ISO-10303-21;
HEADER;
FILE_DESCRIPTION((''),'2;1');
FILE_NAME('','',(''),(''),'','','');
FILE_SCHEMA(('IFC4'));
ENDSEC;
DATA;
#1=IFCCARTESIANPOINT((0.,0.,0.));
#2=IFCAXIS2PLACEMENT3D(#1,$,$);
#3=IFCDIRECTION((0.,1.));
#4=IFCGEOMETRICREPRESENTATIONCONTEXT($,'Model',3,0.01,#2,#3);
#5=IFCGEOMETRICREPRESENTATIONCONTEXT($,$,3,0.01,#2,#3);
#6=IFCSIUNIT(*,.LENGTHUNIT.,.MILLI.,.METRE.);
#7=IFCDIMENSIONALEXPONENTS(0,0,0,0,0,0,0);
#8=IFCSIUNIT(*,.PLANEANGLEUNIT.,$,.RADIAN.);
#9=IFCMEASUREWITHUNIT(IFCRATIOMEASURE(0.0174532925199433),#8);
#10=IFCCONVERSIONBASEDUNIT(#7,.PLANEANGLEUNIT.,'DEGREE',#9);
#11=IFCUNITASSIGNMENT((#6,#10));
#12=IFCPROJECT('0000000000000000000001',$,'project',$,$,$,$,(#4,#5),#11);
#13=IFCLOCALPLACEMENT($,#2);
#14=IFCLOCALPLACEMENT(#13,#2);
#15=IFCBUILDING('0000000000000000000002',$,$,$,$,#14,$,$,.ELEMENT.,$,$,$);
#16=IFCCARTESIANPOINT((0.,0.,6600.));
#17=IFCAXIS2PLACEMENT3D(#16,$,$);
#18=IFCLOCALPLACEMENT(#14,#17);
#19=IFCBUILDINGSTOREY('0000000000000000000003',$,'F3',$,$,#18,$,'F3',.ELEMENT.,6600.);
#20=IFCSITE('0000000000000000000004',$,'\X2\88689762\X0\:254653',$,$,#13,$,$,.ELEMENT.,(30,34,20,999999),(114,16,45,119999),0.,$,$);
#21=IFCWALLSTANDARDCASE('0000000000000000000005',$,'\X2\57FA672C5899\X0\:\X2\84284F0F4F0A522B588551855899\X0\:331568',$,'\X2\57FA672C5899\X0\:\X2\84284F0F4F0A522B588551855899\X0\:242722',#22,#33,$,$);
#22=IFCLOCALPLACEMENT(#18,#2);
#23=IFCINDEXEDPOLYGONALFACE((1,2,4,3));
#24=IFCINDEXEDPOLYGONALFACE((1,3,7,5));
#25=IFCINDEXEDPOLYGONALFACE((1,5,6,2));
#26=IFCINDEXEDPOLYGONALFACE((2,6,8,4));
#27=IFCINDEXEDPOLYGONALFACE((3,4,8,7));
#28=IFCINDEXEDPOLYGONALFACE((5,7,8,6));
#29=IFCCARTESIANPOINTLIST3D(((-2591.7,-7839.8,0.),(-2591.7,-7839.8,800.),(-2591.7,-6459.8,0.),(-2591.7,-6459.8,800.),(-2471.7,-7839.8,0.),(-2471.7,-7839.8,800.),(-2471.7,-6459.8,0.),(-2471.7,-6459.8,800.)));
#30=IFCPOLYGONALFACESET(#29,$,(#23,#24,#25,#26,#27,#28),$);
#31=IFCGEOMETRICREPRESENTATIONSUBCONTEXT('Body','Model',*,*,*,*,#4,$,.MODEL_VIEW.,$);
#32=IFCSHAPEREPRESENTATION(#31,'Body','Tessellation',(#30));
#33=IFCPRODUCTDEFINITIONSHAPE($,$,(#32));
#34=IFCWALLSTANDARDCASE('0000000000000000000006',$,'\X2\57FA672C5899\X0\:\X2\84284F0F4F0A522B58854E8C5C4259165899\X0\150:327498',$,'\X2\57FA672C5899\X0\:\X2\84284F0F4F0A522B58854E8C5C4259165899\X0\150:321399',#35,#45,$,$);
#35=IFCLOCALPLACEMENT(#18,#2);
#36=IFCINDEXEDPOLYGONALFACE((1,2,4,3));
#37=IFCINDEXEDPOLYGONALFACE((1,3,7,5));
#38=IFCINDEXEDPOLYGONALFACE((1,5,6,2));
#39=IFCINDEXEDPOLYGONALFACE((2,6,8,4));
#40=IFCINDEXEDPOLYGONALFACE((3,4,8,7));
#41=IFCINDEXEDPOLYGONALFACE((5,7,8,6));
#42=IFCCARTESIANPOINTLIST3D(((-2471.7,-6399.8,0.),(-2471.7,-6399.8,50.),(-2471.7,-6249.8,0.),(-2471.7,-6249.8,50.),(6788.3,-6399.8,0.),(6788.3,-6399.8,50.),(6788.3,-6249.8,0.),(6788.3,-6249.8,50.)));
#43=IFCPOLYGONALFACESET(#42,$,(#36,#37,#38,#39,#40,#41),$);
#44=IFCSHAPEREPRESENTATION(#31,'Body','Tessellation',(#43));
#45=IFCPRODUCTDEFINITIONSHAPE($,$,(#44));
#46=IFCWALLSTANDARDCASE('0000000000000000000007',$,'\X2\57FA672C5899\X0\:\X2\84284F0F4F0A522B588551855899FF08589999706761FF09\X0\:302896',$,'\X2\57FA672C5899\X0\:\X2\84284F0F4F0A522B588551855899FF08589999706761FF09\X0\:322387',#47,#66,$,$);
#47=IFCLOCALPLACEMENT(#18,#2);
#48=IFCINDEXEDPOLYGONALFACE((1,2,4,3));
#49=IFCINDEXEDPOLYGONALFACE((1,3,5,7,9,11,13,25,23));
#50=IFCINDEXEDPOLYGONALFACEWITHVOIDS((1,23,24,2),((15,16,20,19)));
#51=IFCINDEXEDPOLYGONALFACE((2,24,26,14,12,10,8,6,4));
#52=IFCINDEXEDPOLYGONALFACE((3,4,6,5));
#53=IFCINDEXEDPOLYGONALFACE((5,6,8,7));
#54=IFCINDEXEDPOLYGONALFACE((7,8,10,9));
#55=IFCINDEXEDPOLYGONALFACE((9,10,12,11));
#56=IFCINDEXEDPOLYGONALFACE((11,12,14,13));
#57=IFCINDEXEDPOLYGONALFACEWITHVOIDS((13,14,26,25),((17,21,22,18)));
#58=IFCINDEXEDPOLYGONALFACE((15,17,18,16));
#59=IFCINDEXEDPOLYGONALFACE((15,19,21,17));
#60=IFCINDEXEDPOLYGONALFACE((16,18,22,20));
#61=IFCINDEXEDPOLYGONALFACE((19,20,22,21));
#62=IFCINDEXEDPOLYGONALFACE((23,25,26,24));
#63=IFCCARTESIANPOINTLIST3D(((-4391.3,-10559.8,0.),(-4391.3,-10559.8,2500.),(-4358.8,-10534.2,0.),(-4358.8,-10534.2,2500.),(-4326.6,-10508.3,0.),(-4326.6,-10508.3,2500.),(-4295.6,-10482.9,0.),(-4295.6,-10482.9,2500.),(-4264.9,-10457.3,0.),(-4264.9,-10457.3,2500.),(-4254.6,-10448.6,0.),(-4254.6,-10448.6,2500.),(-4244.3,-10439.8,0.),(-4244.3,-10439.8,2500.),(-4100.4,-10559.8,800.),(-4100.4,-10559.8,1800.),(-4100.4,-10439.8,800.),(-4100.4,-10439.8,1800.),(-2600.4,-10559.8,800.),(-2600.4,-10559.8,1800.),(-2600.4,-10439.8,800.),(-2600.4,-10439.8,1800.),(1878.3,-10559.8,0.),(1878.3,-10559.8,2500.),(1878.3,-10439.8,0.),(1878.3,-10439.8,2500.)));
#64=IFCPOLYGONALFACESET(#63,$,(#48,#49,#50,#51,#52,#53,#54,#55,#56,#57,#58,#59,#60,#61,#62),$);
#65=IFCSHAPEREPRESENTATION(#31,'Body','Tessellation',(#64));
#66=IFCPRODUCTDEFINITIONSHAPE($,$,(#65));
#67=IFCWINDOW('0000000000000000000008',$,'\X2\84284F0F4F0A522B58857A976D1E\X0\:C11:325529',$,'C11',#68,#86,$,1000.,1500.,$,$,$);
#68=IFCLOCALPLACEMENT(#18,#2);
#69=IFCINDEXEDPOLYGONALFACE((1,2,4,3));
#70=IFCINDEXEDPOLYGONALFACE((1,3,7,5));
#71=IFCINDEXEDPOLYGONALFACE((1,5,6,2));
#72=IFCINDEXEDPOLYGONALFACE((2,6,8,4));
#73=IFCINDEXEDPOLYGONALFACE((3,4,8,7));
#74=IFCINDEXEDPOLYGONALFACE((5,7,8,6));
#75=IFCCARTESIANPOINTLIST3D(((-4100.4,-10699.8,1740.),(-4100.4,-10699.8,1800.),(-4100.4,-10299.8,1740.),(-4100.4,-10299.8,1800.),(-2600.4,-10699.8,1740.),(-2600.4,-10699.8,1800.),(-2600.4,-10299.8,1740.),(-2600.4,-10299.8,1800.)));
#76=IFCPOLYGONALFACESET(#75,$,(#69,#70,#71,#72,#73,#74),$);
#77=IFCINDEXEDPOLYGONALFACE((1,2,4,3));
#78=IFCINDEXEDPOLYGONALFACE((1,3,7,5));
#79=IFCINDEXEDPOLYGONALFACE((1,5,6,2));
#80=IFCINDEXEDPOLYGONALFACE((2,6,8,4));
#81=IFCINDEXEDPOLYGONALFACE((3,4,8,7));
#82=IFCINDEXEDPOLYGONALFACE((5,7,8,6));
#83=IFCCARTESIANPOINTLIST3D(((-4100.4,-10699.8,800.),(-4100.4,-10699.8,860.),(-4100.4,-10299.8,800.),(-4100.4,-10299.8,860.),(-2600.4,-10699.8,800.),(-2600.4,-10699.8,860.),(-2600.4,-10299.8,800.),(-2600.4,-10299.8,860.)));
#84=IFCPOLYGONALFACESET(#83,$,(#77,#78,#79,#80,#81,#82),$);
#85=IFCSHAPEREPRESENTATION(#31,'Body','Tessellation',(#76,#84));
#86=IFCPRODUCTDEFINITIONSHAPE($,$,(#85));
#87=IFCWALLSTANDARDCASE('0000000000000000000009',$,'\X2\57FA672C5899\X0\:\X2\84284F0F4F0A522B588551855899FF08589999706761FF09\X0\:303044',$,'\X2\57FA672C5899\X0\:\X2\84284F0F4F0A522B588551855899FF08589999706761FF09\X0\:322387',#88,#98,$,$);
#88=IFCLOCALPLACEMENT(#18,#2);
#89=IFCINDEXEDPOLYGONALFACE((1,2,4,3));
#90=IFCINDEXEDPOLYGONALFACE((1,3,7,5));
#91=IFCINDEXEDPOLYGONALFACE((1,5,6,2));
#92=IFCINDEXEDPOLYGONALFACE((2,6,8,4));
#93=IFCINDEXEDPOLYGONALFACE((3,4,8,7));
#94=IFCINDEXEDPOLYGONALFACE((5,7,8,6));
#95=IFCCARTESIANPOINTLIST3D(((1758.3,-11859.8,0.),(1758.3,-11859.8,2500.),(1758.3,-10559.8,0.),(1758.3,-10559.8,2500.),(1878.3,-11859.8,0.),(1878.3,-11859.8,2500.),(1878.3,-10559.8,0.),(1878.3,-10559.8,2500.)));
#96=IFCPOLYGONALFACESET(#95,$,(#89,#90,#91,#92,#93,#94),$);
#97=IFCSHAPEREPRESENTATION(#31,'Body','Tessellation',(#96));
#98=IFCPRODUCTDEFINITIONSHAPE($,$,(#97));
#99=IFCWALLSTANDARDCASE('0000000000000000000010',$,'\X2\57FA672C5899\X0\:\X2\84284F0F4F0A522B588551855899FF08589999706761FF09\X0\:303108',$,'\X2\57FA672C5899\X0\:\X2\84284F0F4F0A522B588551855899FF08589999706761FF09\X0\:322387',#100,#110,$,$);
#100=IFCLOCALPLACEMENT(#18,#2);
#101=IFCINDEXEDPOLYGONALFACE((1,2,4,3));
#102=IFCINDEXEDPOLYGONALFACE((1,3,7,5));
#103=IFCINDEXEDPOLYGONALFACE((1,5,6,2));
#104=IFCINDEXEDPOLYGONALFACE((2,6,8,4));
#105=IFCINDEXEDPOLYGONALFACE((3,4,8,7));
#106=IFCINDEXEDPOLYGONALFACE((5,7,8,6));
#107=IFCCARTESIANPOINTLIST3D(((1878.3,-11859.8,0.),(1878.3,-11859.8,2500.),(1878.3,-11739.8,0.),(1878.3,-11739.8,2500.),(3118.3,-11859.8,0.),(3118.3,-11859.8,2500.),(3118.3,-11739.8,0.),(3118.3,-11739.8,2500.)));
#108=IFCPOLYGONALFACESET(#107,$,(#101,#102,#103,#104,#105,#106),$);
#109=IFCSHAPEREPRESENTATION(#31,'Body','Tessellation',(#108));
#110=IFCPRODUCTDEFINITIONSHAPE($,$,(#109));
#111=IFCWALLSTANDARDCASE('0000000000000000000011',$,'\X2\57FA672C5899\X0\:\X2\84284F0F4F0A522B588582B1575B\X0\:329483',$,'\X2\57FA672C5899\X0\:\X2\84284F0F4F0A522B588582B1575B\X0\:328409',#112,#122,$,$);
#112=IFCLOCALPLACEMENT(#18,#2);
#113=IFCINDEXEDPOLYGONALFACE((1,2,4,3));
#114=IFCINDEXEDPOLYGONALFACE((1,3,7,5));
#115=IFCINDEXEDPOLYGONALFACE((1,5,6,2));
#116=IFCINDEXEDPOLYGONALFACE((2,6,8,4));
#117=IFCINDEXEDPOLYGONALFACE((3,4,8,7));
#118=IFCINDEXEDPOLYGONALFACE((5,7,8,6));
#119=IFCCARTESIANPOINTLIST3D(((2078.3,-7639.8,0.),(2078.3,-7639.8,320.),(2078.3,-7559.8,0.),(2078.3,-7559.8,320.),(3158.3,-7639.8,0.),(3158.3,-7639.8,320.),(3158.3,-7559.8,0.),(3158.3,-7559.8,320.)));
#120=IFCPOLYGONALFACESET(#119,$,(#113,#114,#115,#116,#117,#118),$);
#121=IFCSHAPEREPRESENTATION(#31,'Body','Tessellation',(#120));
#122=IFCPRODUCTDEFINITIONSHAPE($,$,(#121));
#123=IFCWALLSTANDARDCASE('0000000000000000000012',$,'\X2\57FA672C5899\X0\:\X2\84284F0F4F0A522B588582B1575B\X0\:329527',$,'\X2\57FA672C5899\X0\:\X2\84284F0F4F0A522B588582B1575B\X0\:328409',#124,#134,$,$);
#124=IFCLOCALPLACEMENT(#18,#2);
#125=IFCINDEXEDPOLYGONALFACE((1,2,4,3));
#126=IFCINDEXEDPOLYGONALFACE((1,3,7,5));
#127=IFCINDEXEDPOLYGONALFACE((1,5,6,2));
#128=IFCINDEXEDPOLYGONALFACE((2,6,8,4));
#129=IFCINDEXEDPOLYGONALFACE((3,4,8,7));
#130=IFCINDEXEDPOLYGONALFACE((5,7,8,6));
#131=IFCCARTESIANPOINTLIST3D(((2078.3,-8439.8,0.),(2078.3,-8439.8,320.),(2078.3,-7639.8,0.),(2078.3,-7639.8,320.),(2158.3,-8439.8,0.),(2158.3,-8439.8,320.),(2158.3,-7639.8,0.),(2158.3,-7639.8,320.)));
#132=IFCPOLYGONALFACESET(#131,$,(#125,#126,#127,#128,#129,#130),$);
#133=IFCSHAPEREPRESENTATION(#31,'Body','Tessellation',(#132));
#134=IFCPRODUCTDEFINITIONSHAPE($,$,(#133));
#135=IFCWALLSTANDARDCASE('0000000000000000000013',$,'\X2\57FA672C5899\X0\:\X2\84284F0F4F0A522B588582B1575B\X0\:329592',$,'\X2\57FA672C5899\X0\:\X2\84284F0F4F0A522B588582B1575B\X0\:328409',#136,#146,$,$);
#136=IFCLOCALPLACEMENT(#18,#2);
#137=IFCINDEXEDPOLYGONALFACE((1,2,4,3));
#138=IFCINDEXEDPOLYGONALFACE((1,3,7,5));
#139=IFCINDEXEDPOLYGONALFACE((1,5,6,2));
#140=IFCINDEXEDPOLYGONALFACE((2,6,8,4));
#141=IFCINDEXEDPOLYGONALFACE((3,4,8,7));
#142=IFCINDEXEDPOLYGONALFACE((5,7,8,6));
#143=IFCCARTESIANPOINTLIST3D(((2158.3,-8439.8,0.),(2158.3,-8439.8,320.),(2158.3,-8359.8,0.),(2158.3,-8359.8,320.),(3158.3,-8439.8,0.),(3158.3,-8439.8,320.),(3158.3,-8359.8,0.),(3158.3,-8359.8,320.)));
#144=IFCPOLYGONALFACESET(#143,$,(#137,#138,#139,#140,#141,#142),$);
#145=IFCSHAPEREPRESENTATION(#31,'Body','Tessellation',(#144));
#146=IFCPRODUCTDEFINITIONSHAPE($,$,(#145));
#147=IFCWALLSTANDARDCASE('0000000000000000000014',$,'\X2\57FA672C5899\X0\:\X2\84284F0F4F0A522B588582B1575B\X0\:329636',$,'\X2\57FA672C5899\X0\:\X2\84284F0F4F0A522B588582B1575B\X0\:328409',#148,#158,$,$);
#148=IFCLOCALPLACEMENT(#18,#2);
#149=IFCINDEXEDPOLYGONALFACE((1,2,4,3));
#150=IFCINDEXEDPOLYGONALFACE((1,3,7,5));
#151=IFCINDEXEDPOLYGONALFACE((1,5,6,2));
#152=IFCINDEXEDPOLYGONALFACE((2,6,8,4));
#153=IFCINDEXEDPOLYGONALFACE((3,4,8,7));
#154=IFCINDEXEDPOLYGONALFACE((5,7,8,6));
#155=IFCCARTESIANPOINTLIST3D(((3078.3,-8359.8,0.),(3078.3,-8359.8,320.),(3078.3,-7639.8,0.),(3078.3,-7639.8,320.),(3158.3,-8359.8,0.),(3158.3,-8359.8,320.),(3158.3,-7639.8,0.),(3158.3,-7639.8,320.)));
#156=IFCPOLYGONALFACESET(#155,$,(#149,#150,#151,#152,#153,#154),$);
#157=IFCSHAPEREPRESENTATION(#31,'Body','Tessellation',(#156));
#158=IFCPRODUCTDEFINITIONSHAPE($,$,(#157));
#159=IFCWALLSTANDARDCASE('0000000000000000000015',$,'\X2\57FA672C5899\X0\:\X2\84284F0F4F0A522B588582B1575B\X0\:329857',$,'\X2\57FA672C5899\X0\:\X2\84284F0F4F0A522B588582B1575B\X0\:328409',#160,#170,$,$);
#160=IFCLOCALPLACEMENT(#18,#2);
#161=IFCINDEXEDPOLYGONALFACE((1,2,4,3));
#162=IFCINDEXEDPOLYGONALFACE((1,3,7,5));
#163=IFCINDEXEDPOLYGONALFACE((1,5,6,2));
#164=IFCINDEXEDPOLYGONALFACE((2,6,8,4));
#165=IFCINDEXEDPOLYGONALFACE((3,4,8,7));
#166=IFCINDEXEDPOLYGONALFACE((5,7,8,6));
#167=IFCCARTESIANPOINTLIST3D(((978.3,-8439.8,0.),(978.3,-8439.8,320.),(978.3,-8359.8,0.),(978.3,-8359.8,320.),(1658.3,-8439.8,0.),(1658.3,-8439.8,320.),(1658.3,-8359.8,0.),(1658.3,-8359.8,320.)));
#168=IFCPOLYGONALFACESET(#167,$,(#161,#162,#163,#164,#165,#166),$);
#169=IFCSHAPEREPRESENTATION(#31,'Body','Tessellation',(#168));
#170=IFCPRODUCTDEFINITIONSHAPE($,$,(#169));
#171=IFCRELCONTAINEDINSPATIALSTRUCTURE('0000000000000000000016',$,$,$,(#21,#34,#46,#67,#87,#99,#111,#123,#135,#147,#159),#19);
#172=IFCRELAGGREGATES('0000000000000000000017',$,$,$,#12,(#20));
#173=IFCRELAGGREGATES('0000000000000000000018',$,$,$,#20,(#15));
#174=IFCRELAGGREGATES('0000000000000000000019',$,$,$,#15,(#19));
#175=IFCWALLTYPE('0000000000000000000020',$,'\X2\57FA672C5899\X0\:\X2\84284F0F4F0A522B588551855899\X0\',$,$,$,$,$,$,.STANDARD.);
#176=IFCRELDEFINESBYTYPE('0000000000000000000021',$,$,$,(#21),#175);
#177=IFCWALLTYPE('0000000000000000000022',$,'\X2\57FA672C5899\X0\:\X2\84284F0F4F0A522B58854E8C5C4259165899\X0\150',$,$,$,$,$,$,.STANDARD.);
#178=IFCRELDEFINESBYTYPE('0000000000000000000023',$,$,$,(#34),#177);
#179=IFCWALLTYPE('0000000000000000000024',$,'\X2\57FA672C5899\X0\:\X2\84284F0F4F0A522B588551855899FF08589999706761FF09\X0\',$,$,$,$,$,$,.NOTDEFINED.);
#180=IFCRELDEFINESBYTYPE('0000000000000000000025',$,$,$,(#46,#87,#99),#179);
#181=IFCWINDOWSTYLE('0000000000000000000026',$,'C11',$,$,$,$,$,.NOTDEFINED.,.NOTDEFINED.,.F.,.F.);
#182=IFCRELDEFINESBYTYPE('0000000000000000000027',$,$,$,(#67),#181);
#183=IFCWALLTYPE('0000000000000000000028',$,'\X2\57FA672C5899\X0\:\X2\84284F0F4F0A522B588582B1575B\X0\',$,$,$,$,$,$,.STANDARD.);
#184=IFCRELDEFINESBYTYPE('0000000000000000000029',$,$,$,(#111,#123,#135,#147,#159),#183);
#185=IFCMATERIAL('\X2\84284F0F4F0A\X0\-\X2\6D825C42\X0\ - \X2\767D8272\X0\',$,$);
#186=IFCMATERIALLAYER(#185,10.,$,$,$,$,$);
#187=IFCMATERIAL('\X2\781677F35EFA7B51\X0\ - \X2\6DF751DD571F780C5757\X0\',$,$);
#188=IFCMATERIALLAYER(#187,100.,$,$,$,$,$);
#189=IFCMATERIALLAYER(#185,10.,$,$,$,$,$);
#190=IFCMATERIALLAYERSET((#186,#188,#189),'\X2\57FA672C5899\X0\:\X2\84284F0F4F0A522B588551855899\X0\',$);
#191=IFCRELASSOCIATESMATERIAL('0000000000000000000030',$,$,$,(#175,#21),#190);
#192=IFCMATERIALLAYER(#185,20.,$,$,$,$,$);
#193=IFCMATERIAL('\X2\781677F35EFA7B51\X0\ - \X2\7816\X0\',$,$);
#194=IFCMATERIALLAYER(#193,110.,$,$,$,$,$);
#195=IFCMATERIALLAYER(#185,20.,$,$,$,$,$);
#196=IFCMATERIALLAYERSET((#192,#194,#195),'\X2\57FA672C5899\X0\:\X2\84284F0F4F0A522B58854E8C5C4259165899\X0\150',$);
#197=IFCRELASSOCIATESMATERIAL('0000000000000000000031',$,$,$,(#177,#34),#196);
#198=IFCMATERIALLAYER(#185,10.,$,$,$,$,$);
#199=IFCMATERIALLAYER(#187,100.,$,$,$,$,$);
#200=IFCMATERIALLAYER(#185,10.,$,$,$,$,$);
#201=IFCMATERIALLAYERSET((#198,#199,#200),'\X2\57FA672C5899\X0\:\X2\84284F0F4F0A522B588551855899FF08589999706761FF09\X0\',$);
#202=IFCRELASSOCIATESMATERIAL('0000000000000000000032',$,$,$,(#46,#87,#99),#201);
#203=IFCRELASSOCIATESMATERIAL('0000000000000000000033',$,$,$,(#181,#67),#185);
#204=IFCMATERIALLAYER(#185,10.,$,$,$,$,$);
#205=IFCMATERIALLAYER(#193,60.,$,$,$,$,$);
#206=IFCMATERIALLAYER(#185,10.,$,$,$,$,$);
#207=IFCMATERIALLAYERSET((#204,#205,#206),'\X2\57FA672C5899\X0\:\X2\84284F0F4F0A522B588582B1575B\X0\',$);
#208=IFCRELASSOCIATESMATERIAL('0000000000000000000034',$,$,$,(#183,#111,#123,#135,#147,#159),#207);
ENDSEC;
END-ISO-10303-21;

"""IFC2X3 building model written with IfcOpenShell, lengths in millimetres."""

from ifc_helpers import new_model, entity, si_unit, converted_unit, direction, frame, frame_2d, origin, origin_2d_with_axis, place, context, subcontext, project, spatial, polyline, rectangle, outline, extrude, source, transform, mapped, material, layer, layer_set, layer_usage, type_object, type_shapes, element, fill, save


model = new_model("IFC2X3")

# Units and contexts
model_context = context("Model", 3, precision=0.01, world=origin(), true_north=direction((0.0, 1.0)))
context_of_model = context(None, 3, precision=0.01, world=origin(), true_north=direction((0.0, 1.0)))
body_context = subcontext(model_context, "Body", "Model", "MODEL_VIEW")
ifc_project = project(units=[si_unit("LENGTHUNIT", "METRE", prefix="MILLI"), converted_unit("PLANEANGLEUNIT", "DEGREE", entity("IfcRatioMeasure", 0.0174532925199433), si_unit("PLANEANGLEUNIT", "RADIAN"), dimensions=[0, 0, 0, 0, 0, 0, 0])], contexts=[model_context, context_of_model])

# Site, building, storey
site_placement = place(None, origin())
site = spatial("IfcSite", under=ifc_project, at=site_placement, Name="表面:254653", CompositionType="ELEMENT", RefLatitude=(30, 34, 20, 999999), RefLongitude=(114, 16, 45, 119999), RefElevation=0.0)
building_placement = place(site_placement, origin())
building = spatial("IfcBuilding", under=site, at=building_placement, CompositionType="ELEMENT")
storey_placement = place(building_placement, frame((0.0, 0.0, 6600.0)))
storey = spatial("IfcBuildingStorey", under=building, at=storey_placement, Name="F3", LongName="F3", CompositionType="ELEMENT", Elevation=6600.0)

# Shared definitions
ifc_material_1 = material(Name="萨伏伊-涂层 - 白色")

# Walls
ifc_layer_1 = layer(ifc_material_1, 10.0)
ifc_material_2 = material(Name="砖石建筑 - 混凝土砌块")
ifc_layer_2 = layer(ifc_material_2, 100.0)
ifc_layer_3 = layer(ifc_material_1, 10.0)
ifc_layer_set_1 = layer_set([ifc_layer_1, ifc_layer_2, ifc_layer_3], Name="基本墙:萨伏伊别墅内墙")
ifc_layer_usage_1 = layer_usage(ifc_layer_set_1, "AXIS2", "NEGATIVE", 60.0)
wall_type_1 = type_object("IfcWallType", Name="基本墙:萨伏伊别墅内墙", PredefinedType="STANDARD", material=ifc_layer_set_1)
wall_1_placement = place(storey_placement, frame((-2531.7, -6459.8, 0.0), z_axis=(0.0, 0.0, 1.0), x_axis=(0.0, -1.0, 0.0)))
element("IfcWallStandardCase", 1, at=wall_1_placement, inside=storey, type_object=wall_type_1, material=ifc_layer_usage_1, Name="基本墙:萨伏伊别墅内墙:331568", ObjectType="基本墙:萨伏伊别墅内墙:242722", context=body_context, shape_type="SweptSolid", body=[
    extrude(rectangle(XDim=1380.0, YDim=120.0, at=frame_2d((690.0, 0.0), x_axis=(-1.0, 0.0))), origin(), (0.0, 0.0, 1.0), 800.0),
])
ifc_layer_4 = layer(ifc_material_1, 20.0)
ifc_material_3 = material(Name="砖石建筑 - 砖")
ifc_layer_5 = layer(ifc_material_3, 110.0)
ifc_layer_6 = layer(ifc_material_1, 20.0)
ifc_layer_set_2 = layer_set([ifc_layer_4, ifc_layer_5, ifc_layer_6], Name="基本墙:萨伏伊别墅二层外墙150")
ifc_layer_usage_2 = layer_usage(ifc_layer_set_2, "AXIS2", "NEGATIVE", 75.0)
wall_type_2 = type_object("IfcWallType", Name="基本墙:萨伏伊别墅二层外墙150", PredefinedType="STANDARD", material=ifc_layer_set_2)
wall_2_placement = place(storey_placement, frame((6788.3, -6324.8, 0.0), z_axis=(0.0, 0.0, 1.0), x_axis=(-1.0, 0.0, 0.0)))
element("IfcWallStandardCase", 2, at=wall_2_placement, inside=storey, type_object=wall_type_2, material=ifc_layer_usage_2, Name="基本墙:萨伏伊别墅二层外墙150:327498", ObjectType="基本墙:萨伏伊别墅二层外墙150:321399", context=body_context, shape_type="SweptSolid", body=[
    extrude(rectangle(XDim=9260.0, YDim=150.0, at=frame_2d((4630.0, 0.0), x_axis=(-1.0, 0.0))), origin(), (0.0, 0.0, 1.0), 50.0),
])

# Wall, opening, window
ifc_layer_7 = layer(ifc_material_1, 10.0)
ifc_layer_8 = layer(ifc_material_2, 100.0)
ifc_layer_9 = layer(ifc_material_1, 10.0)
ifc_layer_set_3 = layer_set([ifc_layer_7, ifc_layer_8, ifc_layer_9], Name="基本墙:萨伏伊别墅内墙（墙饰条）")
ifc_layer_usage_3 = layer_usage(ifc_layer_set_3, "AXIS2", "NEGATIVE", 60.0)
wall_type_3 = type_object("IfcWallType", Name="基本墙:萨伏伊别墅内墙（墙饰条）", PredefinedType="NOTDEFINED")
wall_3_placement = place(storey_placement, frame((-4391.3, -10499.8, 0.0)))
wall_3 = element("IfcWallStandardCase", 3, at=wall_3_placement, inside=storey, type_object=wall_type_3, material=ifc_layer_usage_3, Name="基本墙:萨伏伊别墅内墙（墙饰条）:302896", ObjectType="基本墙:萨伏伊别墅内墙（墙饰条）:322387", context=body_context, shape_type="SweptSolid", body=[
    extrude(outline(polyline([(6269.6, -60.0), (6269.6, 60.0), (3959.6, 60.0), (3859.6, 60.0), (1890.9, 60.0), (1790.9, 60.0), (290.9, 60.0), (190.9, 60.0), (147.0, 60.0), (136.7, 51.2), (126.3, 42.5), (95.6, 16.9), (64.7, -8.5), (32.5, -34.4), (0.0, -60.0), (190.9, -60.0), (6149.6, -60.0), (6269.6, -60.0)])), origin(), (0.0, 0.0, 1.0), 2500.0),
])
opening_placement = place(wall_3_placement, frame((290.9, -60.0, 800.0)))
opening = element("IfcOpeningElement", 4, at=opening_placement, cuts=wall_3, ObjectType="Opening", context=body_context, shape_type="SweptSolid", body=[
    extrude(rectangle(XDim=1000.0, YDim=1500.0, at=frame_2d((500.0, 750.0), x_axis=(1.0, 0.0))), frame((0.0, 0.0, 0.0), z_axis=(0.0, 1.0, 0.0), x_axis=(0.0, 0.0, 1.0)), (0.0, 0.0, 1.0), 120.0),
])
window_style = type_object("IfcWindowStyle", Name="C11", ConstructionType="NOTDEFINED", OperationType="NOTDEFINED", ParameterTakesPrecedence=False, Sizeable=False, material=ifc_material_1)
shared_shape = source(origin(), body_context, "Body", "SweptSolid", [
    extrude(rectangle(XDim=400.0, YDim=1500.0, at=origin_2d_with_axis()), frame((750.0, 60.0, 940.0), z_axis=(0.0, 0.0, 1.0), x_axis=(0.0, 1.0, 0.0)), (0.0, 0.0, 1.0), 60.0),
    extrude(rectangle(XDim=400.0, YDim=1500.0, at=origin_2d_with_axis()), frame((750.0, 60.0, 0.0), z_axis=(0.0, 0.0, 1.0), x_axis=(0.0, 1.0, 0.0)), (0.0, 0.0, 1.0), 60.0),
])
type_shapes(window_style, [shared_shape])
window_placement = place(opening_placement, origin())
window = element("IfcWindow", 5, at=window_placement, inside=storey, type_object=window_style, material=ifc_material_1, Name="萨伏伊别墅窗洞:C11:325529", ObjectType="C11", OverallHeight=1000.0, OverallWidth=1500.0, context=body_context, shape_type="MappedRepresentation", body=[
    mapped(shared_shape, transform((0.0, 0.0, 0.0), scale=1.0)),
])
fill(opening, window)

# Walls
ifc_layer_usage_4 = layer_usage(ifc_layer_set_3, "AXIS2", "NEGATIVE", 60.0)
wall_4_placement = place(storey_placement, frame((1818.3, -10559.8, 0.0), z_axis=(0.0, 0.0, 1.0), x_axis=(0.0, -1.0, 0.0)))
element("IfcWallStandardCase", 6, at=wall_4_placement, inside=storey, type_object=wall_type_3, material=ifc_layer_usage_4, Name="基本墙:萨伏伊别墅内墙（墙饰条）:303044", ObjectType="基本墙:萨伏伊别墅内墙（墙饰条）:322387", context=body_context, shape_type="SweptSolid", body=[
    extrude(rectangle(XDim=1300.0, YDim=120.0, at=frame_2d((650.0, 0.0), x_axis=(-1.0, 0.0))), origin(), (0.0, 0.0, 1.0), 2500.0),
])
ifc_layer_usage_5 = layer_usage(ifc_layer_set_3, "AXIS2", "NEGATIVE", 60.0)
wall_5_placement = place(storey_placement, frame((1878.3, -11799.8, 0.0)))
element("IfcWallStandardCase", 7, at=wall_5_placement, inside=storey, type_object=wall_type_3, material=ifc_layer_usage_5, Name="基本墙:萨伏伊别墅内墙（墙饰条）:303108", ObjectType="基本墙:萨伏伊别墅内墙（墙饰条）:322387", context=body_context, shape_type="SweptSolid", body=[
    extrude(rectangle(XDim=1240.0, YDim=120.0, at=frame_2d((620.0, 0.0), x_axis=(-1.0, 0.0))), origin(), (0.0, 0.0, 1.0), 2500.0),
])
ifc_layer_10 = layer(ifc_material_1, 10.0)
ifc_layer_11 = layer(ifc_material_3, 60.0)
ifc_layer_12 = layer(ifc_material_1, 10.0)
ifc_layer_set_4 = layer_set([ifc_layer_10, ifc_layer_11, ifc_layer_12], Name="基本墙:萨伏伊别墅花坛")
ifc_layer_usage_6 = layer_usage(ifc_layer_set_4, "AXIS2", "NEGATIVE", 40.0)
wall_type_4 = type_object("IfcWallType", Name="基本墙:萨伏伊别墅花坛", PredefinedType="STANDARD", material=ifc_layer_set_4)
wall_6_placement = place(storey_placement, frame((3158.3, -7599.8, 0.0), z_axis=(0.0, 0.0, 1.0), x_axis=(-1.0, 0.0, 0.0)))
element("IfcWallStandardCase", 8, at=wall_6_placement, inside=storey, type_object=wall_type_4, material=ifc_layer_usage_6, Name="基本墙:萨伏伊别墅花坛:329483", ObjectType="基本墙:萨伏伊别墅花坛:328409", context=body_context, shape_type="SweptSolid", body=[
    extrude(rectangle(XDim=1080.0, YDim=80.0, at=frame_2d((540.0, 0.0), x_axis=(-1.0, 0.0))), origin(), (0.0, 0.0, 1.0), 320.0),
])
ifc_layer_usage_7 = layer_usage(ifc_layer_set_4, "AXIS2", "NEGATIVE", 40.0)
wall_7_placement = place(storey_placement, frame((2118.3, -7639.8, 0.0), z_axis=(0.0, 0.0, 1.0), x_axis=(0.0, -1.0, 0.0)))
element("IfcWallStandardCase", 9, at=wall_7_placement, inside=storey, type_object=wall_type_4, material=ifc_layer_usage_7, Name="基本墙:萨伏伊别墅花坛:329527", ObjectType="基本墙:萨伏伊别墅花坛:328409", context=body_context, shape_type="SweptSolid", body=[
    extrude(rectangle(XDim=800.0, YDim=80.0, at=frame_2d((400.0, 0.0), x_axis=(-1.0, 0.0))), origin(), (0.0, 0.0, 1.0), 320.0),
])
ifc_layer_usage_8 = layer_usage(ifc_layer_set_4, "AXIS2", "NEGATIVE", 40.0)
wall_8_placement = place(storey_placement, frame((2158.3, -8399.8, 0.0)))
element("IfcWallStandardCase", 10, at=wall_8_placement, inside=storey, type_object=wall_type_4, material=ifc_layer_usage_8, Name="基本墙:萨伏伊别墅花坛:329592", ObjectType="基本墙:萨伏伊别墅花坛:328409", context=body_context, shape_type="SweptSolid", body=[
    extrude(rectangle(XDim=1000.0, YDim=80.0, at=frame_2d((500.0, 0.0), x_axis=(-1.0, 0.0))), origin(), (0.0, 0.0, 1.0), 320.0),
])
ifc_layer_usage_9 = layer_usage(ifc_layer_set_4, "AXIS2", "NEGATIVE", 40.0)
wall_9_placement = place(storey_placement, frame((3118.3, -8359.8, 0.0), z_axis=(0.0, 0.0, 1.0), x_axis=(0.0, 1.0, 0.0)))
element("IfcWallStandardCase", 11, at=wall_9_placement, inside=storey, type_object=wall_type_4, material=ifc_layer_usage_9, Name="基本墙:萨伏伊别墅花坛:329636", ObjectType="基本墙:萨伏伊别墅花坛:328409", context=body_context, shape_type="SweptSolid", body=[
    extrude(rectangle(XDim=720.0, YDim=80.0, at=frame_2d((360.0, 0.0), x_axis=(-1.0, 0.0))), origin(), (0.0, 0.0, 1.0), 320.0),
])
ifc_layer_usage_10 = layer_usage(ifc_layer_set_4, "AXIS2", "NEGATIVE", 40.0)
wall_10_placement = place(storey_placement, frame((1658.3, -8399.8, 0.0), z_axis=(0.0, 0.0, 1.0), x_axis=(-1.0, 0.0, 0.0)))
element("IfcWallStandardCase", 12, at=wall_10_placement, inside=storey, type_object=wall_type_4, material=ifc_layer_usage_10, Name="基本墙:萨伏伊别墅花坛:329857", ObjectType="基本墙:萨伏伊别墅花坛:328409", context=body_context, shape_type="SweptSolid", body=[
    extrude(rectangle(XDim=680.0, YDim=80.0, at=frame_2d((340.0, 0.0), x_axis=(-1.0, 0.0))), origin(), (0.0, 0.0, 1.0), 320.0),
])

save(model, "model.ifc")
